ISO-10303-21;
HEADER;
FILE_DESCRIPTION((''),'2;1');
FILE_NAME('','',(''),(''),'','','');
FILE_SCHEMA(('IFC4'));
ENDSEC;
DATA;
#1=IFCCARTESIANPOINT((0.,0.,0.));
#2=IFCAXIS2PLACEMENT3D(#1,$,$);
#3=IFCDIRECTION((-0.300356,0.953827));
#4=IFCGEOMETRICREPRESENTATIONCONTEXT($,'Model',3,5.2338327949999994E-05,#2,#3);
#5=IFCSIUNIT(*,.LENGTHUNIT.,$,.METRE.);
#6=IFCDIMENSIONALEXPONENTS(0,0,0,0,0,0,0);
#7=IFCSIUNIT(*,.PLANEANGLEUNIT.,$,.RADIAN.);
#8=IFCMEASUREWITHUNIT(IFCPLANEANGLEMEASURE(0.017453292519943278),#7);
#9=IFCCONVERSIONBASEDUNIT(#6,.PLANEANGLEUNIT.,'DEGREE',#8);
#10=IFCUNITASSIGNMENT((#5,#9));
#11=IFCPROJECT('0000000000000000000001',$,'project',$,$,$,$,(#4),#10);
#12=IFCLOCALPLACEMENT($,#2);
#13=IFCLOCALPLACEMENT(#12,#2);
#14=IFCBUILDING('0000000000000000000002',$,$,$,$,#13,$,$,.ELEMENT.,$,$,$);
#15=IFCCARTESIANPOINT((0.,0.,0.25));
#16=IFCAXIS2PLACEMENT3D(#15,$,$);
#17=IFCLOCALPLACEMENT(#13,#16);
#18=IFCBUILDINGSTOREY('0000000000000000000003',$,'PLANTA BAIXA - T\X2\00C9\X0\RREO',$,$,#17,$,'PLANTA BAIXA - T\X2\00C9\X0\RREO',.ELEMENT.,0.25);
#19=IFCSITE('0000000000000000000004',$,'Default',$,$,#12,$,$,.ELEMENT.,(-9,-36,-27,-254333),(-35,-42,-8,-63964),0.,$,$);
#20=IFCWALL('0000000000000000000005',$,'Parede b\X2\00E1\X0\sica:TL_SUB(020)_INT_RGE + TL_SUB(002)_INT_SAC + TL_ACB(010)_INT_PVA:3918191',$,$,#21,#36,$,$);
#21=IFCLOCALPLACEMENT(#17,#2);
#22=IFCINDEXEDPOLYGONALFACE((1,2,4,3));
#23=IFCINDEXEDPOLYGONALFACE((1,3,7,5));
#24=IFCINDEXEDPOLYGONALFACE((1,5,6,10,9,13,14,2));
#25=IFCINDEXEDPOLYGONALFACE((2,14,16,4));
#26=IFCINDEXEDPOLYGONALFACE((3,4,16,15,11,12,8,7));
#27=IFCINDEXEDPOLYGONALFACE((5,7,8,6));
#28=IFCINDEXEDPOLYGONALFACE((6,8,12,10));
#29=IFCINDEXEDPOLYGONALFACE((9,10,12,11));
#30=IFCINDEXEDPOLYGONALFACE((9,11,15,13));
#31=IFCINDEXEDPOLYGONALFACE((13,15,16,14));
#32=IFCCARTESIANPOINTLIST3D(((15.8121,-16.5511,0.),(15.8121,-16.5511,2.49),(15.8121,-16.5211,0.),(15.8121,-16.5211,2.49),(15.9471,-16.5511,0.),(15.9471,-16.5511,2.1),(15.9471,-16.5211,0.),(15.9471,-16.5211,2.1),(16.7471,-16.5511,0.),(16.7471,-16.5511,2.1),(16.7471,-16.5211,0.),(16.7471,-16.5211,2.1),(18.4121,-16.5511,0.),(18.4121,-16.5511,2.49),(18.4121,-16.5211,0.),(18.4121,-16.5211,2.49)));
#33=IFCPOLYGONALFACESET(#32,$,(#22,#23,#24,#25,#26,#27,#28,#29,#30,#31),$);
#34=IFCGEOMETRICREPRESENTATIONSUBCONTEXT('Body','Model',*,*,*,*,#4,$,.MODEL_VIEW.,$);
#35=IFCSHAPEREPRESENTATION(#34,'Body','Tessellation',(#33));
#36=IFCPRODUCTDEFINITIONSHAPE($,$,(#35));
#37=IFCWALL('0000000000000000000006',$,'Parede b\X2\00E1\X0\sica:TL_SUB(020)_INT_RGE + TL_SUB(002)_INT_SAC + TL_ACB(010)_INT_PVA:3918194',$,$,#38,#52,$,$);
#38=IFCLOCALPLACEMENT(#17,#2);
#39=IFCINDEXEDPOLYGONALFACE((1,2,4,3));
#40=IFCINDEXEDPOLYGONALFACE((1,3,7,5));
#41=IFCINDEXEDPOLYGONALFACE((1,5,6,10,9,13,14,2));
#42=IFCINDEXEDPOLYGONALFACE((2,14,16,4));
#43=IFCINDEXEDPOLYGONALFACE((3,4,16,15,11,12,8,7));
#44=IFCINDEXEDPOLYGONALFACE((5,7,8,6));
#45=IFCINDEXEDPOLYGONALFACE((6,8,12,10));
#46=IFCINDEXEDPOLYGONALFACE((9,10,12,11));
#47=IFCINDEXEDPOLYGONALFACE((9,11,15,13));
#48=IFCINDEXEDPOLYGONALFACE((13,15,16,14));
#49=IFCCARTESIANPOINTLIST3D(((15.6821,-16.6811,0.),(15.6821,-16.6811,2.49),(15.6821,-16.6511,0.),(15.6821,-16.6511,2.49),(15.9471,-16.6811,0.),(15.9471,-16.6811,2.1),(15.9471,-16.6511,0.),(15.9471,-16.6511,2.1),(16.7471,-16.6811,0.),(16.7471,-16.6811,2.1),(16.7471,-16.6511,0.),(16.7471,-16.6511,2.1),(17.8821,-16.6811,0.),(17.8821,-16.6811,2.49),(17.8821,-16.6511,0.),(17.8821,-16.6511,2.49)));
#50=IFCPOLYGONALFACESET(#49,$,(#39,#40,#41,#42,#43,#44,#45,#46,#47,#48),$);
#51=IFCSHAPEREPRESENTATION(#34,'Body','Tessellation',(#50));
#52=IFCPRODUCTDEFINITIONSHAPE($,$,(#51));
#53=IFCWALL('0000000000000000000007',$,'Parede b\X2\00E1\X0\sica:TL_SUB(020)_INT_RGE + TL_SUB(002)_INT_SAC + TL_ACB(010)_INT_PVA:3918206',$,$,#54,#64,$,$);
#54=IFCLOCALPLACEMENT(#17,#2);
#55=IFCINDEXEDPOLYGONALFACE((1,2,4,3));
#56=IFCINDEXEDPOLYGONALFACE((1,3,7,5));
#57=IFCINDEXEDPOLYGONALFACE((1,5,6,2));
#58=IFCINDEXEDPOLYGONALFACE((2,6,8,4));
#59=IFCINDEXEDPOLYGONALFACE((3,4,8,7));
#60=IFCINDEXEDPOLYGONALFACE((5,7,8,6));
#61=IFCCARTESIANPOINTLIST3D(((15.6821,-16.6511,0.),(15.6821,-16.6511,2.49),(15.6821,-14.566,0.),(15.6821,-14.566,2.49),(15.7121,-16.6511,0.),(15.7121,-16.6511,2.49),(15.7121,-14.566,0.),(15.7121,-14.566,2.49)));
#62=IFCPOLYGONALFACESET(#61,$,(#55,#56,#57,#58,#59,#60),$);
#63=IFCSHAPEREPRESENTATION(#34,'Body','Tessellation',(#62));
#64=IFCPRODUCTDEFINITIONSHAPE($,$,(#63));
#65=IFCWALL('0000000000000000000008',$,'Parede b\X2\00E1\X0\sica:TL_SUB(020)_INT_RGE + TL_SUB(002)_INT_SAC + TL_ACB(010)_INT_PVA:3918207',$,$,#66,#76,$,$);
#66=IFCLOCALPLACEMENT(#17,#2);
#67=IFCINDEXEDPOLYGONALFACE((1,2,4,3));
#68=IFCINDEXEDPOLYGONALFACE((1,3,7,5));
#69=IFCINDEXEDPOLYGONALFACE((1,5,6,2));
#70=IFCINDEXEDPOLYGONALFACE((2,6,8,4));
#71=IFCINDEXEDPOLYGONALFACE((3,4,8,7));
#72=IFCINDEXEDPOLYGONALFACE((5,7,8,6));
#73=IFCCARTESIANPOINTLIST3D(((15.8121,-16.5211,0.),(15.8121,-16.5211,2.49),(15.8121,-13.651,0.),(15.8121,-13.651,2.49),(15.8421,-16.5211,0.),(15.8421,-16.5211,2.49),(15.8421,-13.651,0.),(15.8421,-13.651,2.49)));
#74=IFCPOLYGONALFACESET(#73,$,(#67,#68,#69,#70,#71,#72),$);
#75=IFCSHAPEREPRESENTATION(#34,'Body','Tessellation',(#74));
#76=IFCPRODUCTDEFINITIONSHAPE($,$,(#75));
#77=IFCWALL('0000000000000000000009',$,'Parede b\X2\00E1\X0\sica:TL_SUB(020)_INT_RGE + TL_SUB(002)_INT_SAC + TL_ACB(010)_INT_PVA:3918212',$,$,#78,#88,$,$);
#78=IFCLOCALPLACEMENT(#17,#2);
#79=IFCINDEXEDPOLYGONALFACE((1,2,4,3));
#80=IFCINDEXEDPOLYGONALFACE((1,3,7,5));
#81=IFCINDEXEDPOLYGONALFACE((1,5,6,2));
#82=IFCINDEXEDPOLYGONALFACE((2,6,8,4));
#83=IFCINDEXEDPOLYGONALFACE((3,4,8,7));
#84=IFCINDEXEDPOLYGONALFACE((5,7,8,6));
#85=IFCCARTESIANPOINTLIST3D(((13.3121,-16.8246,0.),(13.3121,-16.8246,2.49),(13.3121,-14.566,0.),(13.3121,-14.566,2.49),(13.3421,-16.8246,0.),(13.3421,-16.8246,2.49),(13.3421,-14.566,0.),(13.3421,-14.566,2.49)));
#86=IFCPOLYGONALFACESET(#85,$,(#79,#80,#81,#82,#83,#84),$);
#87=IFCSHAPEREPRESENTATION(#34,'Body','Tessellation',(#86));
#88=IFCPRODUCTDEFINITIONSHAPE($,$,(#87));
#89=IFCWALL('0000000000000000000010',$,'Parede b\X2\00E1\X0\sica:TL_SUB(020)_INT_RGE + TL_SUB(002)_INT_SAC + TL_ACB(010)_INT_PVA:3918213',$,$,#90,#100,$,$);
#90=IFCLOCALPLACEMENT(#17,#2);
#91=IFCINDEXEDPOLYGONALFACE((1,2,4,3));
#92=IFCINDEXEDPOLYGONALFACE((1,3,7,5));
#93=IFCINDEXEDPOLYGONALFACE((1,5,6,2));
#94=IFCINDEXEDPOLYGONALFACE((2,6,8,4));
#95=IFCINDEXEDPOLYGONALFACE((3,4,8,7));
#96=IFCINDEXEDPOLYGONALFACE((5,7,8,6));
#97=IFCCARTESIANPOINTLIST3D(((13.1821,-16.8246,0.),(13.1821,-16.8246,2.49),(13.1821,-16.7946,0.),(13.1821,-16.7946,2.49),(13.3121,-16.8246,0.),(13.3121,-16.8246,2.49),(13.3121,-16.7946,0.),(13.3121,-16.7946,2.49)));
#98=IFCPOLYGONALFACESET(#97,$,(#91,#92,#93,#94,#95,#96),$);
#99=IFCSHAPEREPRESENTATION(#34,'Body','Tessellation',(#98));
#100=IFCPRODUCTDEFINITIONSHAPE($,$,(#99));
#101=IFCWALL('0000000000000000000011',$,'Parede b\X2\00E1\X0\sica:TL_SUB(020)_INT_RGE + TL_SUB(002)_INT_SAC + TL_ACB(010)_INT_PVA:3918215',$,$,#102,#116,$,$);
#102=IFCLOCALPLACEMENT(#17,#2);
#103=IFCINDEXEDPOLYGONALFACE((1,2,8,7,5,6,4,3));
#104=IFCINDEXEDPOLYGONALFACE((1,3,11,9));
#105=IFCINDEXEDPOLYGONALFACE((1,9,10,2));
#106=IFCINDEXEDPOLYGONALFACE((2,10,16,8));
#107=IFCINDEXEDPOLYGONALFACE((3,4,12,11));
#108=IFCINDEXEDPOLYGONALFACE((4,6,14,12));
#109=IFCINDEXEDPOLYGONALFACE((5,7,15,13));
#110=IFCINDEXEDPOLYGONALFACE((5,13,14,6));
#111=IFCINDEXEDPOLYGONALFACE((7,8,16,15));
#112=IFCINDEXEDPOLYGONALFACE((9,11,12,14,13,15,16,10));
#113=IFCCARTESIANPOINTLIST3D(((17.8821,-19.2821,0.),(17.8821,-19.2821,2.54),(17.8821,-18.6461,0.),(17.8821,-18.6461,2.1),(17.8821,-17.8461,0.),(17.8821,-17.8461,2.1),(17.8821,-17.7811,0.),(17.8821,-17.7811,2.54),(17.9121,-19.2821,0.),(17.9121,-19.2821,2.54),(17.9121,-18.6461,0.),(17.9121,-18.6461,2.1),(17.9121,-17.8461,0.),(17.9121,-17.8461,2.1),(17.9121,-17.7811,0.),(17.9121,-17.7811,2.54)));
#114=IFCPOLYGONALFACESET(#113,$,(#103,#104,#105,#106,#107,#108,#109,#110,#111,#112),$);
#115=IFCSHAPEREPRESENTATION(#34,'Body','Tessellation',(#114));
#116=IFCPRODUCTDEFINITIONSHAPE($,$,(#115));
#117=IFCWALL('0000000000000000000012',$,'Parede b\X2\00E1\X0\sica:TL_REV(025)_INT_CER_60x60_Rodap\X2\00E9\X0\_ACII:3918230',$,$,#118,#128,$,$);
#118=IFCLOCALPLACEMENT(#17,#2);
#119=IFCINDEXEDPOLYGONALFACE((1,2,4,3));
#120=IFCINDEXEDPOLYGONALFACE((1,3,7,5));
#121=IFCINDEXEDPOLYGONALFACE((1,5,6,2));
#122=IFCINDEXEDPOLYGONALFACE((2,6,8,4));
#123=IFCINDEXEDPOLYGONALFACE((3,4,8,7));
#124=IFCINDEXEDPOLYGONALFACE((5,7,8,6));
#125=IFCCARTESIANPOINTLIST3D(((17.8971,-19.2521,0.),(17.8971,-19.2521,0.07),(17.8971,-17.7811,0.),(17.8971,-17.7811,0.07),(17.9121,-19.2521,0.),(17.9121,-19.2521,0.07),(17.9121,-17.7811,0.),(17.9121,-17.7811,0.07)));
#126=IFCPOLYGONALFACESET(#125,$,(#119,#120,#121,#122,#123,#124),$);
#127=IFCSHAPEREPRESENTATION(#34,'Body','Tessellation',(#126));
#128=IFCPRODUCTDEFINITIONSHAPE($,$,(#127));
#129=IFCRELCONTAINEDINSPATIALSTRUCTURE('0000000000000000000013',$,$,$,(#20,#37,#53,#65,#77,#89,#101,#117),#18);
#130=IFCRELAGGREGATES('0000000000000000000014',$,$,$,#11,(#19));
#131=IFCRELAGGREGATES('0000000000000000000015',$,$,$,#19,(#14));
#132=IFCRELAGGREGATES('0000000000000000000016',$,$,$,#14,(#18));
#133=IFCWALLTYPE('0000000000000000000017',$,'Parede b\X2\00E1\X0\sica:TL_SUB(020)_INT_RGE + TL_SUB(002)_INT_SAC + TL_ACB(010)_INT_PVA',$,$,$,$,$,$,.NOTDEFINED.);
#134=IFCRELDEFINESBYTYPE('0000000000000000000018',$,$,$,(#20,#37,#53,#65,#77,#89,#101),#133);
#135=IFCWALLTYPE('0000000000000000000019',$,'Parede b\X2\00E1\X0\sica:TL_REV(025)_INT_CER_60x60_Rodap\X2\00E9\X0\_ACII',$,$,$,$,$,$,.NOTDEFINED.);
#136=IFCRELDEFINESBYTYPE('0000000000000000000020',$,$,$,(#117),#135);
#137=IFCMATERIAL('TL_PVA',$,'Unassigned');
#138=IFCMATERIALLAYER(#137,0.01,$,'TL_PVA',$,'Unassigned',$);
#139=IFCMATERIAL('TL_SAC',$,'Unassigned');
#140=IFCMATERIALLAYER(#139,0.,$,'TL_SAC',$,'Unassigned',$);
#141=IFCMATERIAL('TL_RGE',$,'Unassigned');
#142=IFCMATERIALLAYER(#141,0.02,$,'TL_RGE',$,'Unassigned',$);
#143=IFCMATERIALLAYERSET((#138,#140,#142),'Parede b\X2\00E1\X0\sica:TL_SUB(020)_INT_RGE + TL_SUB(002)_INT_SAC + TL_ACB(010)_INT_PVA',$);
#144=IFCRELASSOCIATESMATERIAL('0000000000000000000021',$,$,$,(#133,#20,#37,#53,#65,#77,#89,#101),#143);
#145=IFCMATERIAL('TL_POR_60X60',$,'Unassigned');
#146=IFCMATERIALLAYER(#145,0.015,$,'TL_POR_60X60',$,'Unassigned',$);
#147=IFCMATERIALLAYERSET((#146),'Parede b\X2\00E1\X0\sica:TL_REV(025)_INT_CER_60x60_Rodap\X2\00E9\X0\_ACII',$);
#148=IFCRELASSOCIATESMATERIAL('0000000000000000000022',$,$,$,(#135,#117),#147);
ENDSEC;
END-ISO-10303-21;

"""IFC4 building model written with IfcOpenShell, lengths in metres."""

from ifc_helpers import new_model, entity, si_unit, converted_unit, direction, frame, frame_2d, origin, place, context, subcontext, project, spatial, rectangle, extrude, material, layer, layer_set, layer_usage, type_object, element, save


model = new_model("IFC4")

# Units and contexts
model_context = context("Model", 3, precision=5.2338327949999994e-05, world=origin(), true_north=direction((-0.300356, 0.953827)))
body_context = subcontext(model_context, "Body", "Model", "MODEL_VIEW")
ifc_project = project(units=[si_unit("LENGTHUNIT", "METRE"), converted_unit("PLANEANGLEUNIT", "DEGREE", entity("IfcPlaneAngleMeasure", 0.017453292519943278), si_unit("PLANEANGLEUNIT", "RADIAN"), dimensions=[0, 0, 0, 0, 0, 0, 0])], contexts=[model_context])

# Site, building, storey
site_placement = place(None, origin())
site = spatial("IfcSite", under=ifc_project, at=site_placement, Name="Default", CompositionType="ELEMENT", RefLatitude=(-9, -36, -27, -254333), RefLongitude=(-35, -42, -8, -63964), RefElevation=0.0)
building_placement = place(site_placement, origin())
building = spatial("IfcBuilding", under=site, at=building_placement, CompositionType="ELEMENT")
storey_placement = place(building_placement, frame((0.0, 0.0, 0.25)))
storey = spatial("IfcBuildingStorey", under=building, at=storey_placement, Name="PLANTA BAIXA - TÉRREO", LongName="PLANTA BAIXA - TÉRREO", CompositionType="ELEMENT", Elevation=0.25)

# Walls, openings
ifc_material_1 = material(Name="TL_PVA", Category="Unassigned")
ifc_layer_1 = layer(ifc_material_1, 0.01, Name="TL_PVA", Category="Unassigned")
ifc_material_2 = material(Name="TL_SAC", Category="Unassigned")
ifc_layer_2 = layer(ifc_material_2, 0.0, Name="TL_SAC", Category="Unassigned")
ifc_material_3 = material(Name="TL_RGE", Category="Unassigned")
ifc_layer_3 = layer(ifc_material_3, 0.02, Name="TL_RGE", Category="Unassigned")
ifc_layer_set_1 = layer_set([ifc_layer_1, ifc_layer_2, ifc_layer_3], Name="Parede básica:TL_SUB(020)_INT_RGE + TL_SUB(002)_INT_SAC + TL_ACB(010)_INT_PVA")
wall_type_1 = type_object("IfcWallType", Name="Parede básica:TL_SUB(020)_INT_RGE + TL_SUB(002)_INT_SAC + TL_ACB(010)_INT_PVA", PredefinedType="NOTDEFINED", material=ifc_layer_set_1)
ifc_layer_usage_1 = layer_usage(ifc_layer_set_1, "AXIS2", "NEGATIVE", 0.015)
wall_1_placement = place(storey_placement, frame((15.8121, -16.5361, 0.0)))
wall_1 = element("IfcWall", 1, at=wall_1_placement, inside=storey, type_object=wall_type_1, material=ifc_layer_usage_1, Name="Parede básica:TL_SUB(020)_INT_RGE + TL_SUB(002)_INT_SAC + TL_ACB(010)_INT_PVA:3918191", context=body_context, shape_type="SweptSolid", body=[
    extrude(rectangle(XDim=2.6, YDim=0.03, at=frame_2d((1.3, 0.0), x_axis=(-1.0, 0.0))), origin(), (0.0, 0.0, 1.0), 2.49),
])
opening_1_placement = place(wall_1_placement, frame((-15.8121, 16.5361, 0.0)))
element("IfcOpeningElement", 2, at=opening_1_placement, cuts=wall_1, PredefinedType="OPENING", context=body_context, shape_type="SweptSolid", body=[
    extrude(rectangle(XDim=2.1, YDim=0.8, at=frame_2d((0.0, 0.0), x_axis=(1.0, 0.0))), frame((16.3471, -18.1751, 1.05), z_axis=(0.0, 1.0, 0.0), x_axis=(0.0, 0.0, 1.0)), (0.0, 0.0, 1.0), 3.048),
])
ifc_layer_usage_2 = layer_usage(ifc_layer_set_1, "AXIS2", "NEGATIVE", 0.015)
wall_2_placement = place(storey_placement, frame((17.8821, -16.6661, 0.0), z_axis=(0.0, 0.0, 1.0), x_axis=(-1.0, 0.0, 0.0)))
wall_2 = element("IfcWall", 3, at=wall_2_placement, inside=storey, type_object=wall_type_1, material=ifc_layer_usage_2, Name="Parede básica:TL_SUB(020)_INT_RGE + TL_SUB(002)_INT_SAC + TL_ACB(010)_INT_PVA:3918194", context=body_context, shape_type="SweptSolid", body=[
    extrude(rectangle(XDim=2.2, YDim=0.03, at=frame_2d((1.1, 0.0), x_axis=(-1.0, 0.0))), origin(), (0.0, 0.0, 1.0), 2.49),
])
opening_2_placement = place(wall_2_placement, frame((17.8821, -16.6661, 0.0)))
element("IfcOpeningElement", 4, at=opening_2_placement, cuts=wall_2, PredefinedType="OPENING", context=body_context, shape_type="SweptSolid", body=[
    extrude(rectangle(XDim=2.1, YDim=0.8, at=frame_2d((0.0, 0.0), x_axis=(0.0, 1.0))), frame((-16.3471, 15.1271, 1.05), z_axis=(0.0, 1.0, 0.0), x_axis=(-1.0, 0.0, 0.0)), (0.0, 0.0, 1.0), 3.048),
])

# Walls
ifc_layer_usage_3 = layer_usage(ifc_layer_set_1, "AXIS2", "POSITIVE", -0.015)
wall_3_placement = place(storey_placement, frame((15.6971, -14.566, 0.0), z_axis=(0.0, 0.0, 1.0), x_axis=(0.0, -1.0, 0.0)))
element("IfcWall", 5, at=wall_3_placement, inside=storey, type_object=wall_type_1, material=ifc_layer_usage_3, Name="Parede básica:TL_SUB(020)_INT_RGE + TL_SUB(002)_INT_SAC + TL_ACB(010)_INT_PVA:3918206", context=body_context, shape_type="SweptSolid", body=[
    extrude(rectangle(XDim=2.0851, YDim=0.03, at=frame_2d((1.0426, 0.0), x_axis=(-1.0, 0.0))), origin(), (0.0, 0.0, 1.0), 2.49),
])
ifc_layer_usage_4 = layer_usage(ifc_layer_set_1, "AXIS2", "POSITIVE", -0.015)
wall_4_placement = place(storey_placement, frame((15.8271, -16.5211, 0.0), z_axis=(0.0, 0.0, 1.0), x_axis=(0.0, 1.0, 0.0)))
element("IfcWall", 6, at=wall_4_placement, inside=storey, type_object=wall_type_1, material=ifc_layer_usage_4, Name="Parede básica:TL_SUB(020)_INT_RGE + TL_SUB(002)_INT_SAC + TL_ACB(010)_INT_PVA:3918207", context=body_context, shape_type="SweptSolid", body=[
    extrude(rectangle(XDim=2.8701, YDim=0.03, at=frame_2d((1.4351, 0.0), x_axis=(-1.0, 0.0))), origin(), (0.0, 0.0, 1.0), 2.49),
])
ifc_layer_usage_5 = layer_usage(ifc_layer_set_1, "AXIS2", "POSITIVE", -0.015)
wall_5_placement = place(storey_placement, frame((13.3271, -16.8246, 0.0), z_axis=(0.0, 0.0, 1.0), x_axis=(0.0, 1.0, 0.0)))
element("IfcWall", 7, at=wall_5_placement, inside=storey, type_object=wall_type_1, material=ifc_layer_usage_5, Name="Parede básica:TL_SUB(020)_INT_RGE + TL_SUB(002)_INT_SAC + TL_ACB(010)_INT_PVA:3918212", context=body_context, shape_type="SweptSolid", body=[
    extrude(rectangle(XDim=2.2587, YDim=0.03, at=frame_2d((1.1293, 0.0), x_axis=(-1.0, 0.0))), origin(), (0.0, 0.0, 1.0), 2.49),
])
ifc_layer_usage_6 = layer_usage(ifc_layer_set_1, "AXIS2", "POSITIVE", -0.015)
wall_6_placement = place(storey_placement, frame((13.1821, -16.8096, 0.0)))
element("IfcWall", 8, at=wall_6_placement, inside=storey, type_object=wall_type_1, material=ifc_layer_usage_6, Name="Parede básica:TL_SUB(020)_INT_RGE + TL_SUB(002)_INT_SAC + TL_ACB(010)_INT_PVA:3918213", context=body_context, shape_type="SweptSolid", body=[
    extrude(rectangle(XDim=0.13, YDim=0.03, at=frame_2d((0.065, 0.0), x_axis=(-1.0, 0.0))), origin(), (0.0, 0.0, 1.0), 2.49),
])

# Wall, opening
ifc_layer_usage_7 = layer_usage(ifc_layer_set_1, "AXIS2", "POSITIVE", -0.015)
wall_7_placement = place(storey_placement, frame((17.8971, -17.7811, 0.0), z_axis=(0.0, 0.0, 1.0), x_axis=(0.0, -1.0, 0.0)))
wall_7 = element("IfcWall", 9, at=wall_7_placement, inside=storey, type_object=wall_type_1, material=ifc_layer_usage_7, Name="Parede básica:TL_SUB(020)_INT_RGE + TL_SUB(002)_INT_SAC + TL_ACB(010)_INT_PVA:3918215", context=body_context, shape_type="SweptSolid", body=[
    extrude(rectangle(XDim=1.501, YDim=0.03, at=frame_2d((0.7505, 0.0), x_axis=(-1.0, 0.0))), origin(), (0.0, 0.0, 1.0), 2.54),
])
opening_3_placement = place(wall_7_placement, frame((0.065, -0.015, 0.0)))
element("IfcOpeningElement", 10, at=opening_3_placement, cuts=wall_7, PredefinedType="OPENING", context=body_context, shape_type="SweptSolid", body=[
    extrude(rectangle(XDim=2.1, YDim=0.8, at=frame_2d((1.05, 0.4), x_axis=(1.0, 0.0))), frame((0.0, 0.0, 0.0), z_axis=(0.0, 1.0, 0.0), x_axis=(0.0, 0.0, 1.0)), (0.0, 0.0, 1.0), 0.03),
])

# Wall
ifc_material_4 = material(Name="TL_POR_60X60", Category="Unassigned")
ifc_layer_4 = layer(ifc_material_4, 0.015, Name="TL_POR_60X60", Category="Unassigned")
ifc_layer_set_2 = layer_set([ifc_layer_4], Name="Parede básica:TL_REV(025)_INT_CER_60x60_Rodapé_ACII")
ifc_layer_usage_8 = layer_usage(ifc_layer_set_2, "AXIS2", "NEGATIVE", 0.0075)
wall_type_2 = type_object("IfcWallType", Name="Parede básica:TL_REV(025)_INT_CER_60x60_Rodapé_ACII", PredefinedType="NOTDEFINED", material=ifc_layer_set_2)
wall_8_placement = place(storey_placement, frame((17.9046, -19.2521, 0.0), z_axis=(0.0, 0.0, 1.0), x_axis=(0.0, 1.0, 0.0)))
element("IfcWall", 11, at=wall_8_placement, inside=storey, type_object=wall_type_2, material=ifc_layer_usage_8, Name="Parede básica:TL_REV(025)_INT_CER_60x60_Rodapé_ACII:3918230", context=body_context, shape_type="SweptSolid", body=[
    extrude(rectangle(XDim=1.471, YDim=0.015, at=frame_2d((0.7355, 0.0), x_axis=(-1.0, 0.0))), origin(), (0.0, 0.0, 1.0), 0.07),
])

save(model, "model.ifc")
